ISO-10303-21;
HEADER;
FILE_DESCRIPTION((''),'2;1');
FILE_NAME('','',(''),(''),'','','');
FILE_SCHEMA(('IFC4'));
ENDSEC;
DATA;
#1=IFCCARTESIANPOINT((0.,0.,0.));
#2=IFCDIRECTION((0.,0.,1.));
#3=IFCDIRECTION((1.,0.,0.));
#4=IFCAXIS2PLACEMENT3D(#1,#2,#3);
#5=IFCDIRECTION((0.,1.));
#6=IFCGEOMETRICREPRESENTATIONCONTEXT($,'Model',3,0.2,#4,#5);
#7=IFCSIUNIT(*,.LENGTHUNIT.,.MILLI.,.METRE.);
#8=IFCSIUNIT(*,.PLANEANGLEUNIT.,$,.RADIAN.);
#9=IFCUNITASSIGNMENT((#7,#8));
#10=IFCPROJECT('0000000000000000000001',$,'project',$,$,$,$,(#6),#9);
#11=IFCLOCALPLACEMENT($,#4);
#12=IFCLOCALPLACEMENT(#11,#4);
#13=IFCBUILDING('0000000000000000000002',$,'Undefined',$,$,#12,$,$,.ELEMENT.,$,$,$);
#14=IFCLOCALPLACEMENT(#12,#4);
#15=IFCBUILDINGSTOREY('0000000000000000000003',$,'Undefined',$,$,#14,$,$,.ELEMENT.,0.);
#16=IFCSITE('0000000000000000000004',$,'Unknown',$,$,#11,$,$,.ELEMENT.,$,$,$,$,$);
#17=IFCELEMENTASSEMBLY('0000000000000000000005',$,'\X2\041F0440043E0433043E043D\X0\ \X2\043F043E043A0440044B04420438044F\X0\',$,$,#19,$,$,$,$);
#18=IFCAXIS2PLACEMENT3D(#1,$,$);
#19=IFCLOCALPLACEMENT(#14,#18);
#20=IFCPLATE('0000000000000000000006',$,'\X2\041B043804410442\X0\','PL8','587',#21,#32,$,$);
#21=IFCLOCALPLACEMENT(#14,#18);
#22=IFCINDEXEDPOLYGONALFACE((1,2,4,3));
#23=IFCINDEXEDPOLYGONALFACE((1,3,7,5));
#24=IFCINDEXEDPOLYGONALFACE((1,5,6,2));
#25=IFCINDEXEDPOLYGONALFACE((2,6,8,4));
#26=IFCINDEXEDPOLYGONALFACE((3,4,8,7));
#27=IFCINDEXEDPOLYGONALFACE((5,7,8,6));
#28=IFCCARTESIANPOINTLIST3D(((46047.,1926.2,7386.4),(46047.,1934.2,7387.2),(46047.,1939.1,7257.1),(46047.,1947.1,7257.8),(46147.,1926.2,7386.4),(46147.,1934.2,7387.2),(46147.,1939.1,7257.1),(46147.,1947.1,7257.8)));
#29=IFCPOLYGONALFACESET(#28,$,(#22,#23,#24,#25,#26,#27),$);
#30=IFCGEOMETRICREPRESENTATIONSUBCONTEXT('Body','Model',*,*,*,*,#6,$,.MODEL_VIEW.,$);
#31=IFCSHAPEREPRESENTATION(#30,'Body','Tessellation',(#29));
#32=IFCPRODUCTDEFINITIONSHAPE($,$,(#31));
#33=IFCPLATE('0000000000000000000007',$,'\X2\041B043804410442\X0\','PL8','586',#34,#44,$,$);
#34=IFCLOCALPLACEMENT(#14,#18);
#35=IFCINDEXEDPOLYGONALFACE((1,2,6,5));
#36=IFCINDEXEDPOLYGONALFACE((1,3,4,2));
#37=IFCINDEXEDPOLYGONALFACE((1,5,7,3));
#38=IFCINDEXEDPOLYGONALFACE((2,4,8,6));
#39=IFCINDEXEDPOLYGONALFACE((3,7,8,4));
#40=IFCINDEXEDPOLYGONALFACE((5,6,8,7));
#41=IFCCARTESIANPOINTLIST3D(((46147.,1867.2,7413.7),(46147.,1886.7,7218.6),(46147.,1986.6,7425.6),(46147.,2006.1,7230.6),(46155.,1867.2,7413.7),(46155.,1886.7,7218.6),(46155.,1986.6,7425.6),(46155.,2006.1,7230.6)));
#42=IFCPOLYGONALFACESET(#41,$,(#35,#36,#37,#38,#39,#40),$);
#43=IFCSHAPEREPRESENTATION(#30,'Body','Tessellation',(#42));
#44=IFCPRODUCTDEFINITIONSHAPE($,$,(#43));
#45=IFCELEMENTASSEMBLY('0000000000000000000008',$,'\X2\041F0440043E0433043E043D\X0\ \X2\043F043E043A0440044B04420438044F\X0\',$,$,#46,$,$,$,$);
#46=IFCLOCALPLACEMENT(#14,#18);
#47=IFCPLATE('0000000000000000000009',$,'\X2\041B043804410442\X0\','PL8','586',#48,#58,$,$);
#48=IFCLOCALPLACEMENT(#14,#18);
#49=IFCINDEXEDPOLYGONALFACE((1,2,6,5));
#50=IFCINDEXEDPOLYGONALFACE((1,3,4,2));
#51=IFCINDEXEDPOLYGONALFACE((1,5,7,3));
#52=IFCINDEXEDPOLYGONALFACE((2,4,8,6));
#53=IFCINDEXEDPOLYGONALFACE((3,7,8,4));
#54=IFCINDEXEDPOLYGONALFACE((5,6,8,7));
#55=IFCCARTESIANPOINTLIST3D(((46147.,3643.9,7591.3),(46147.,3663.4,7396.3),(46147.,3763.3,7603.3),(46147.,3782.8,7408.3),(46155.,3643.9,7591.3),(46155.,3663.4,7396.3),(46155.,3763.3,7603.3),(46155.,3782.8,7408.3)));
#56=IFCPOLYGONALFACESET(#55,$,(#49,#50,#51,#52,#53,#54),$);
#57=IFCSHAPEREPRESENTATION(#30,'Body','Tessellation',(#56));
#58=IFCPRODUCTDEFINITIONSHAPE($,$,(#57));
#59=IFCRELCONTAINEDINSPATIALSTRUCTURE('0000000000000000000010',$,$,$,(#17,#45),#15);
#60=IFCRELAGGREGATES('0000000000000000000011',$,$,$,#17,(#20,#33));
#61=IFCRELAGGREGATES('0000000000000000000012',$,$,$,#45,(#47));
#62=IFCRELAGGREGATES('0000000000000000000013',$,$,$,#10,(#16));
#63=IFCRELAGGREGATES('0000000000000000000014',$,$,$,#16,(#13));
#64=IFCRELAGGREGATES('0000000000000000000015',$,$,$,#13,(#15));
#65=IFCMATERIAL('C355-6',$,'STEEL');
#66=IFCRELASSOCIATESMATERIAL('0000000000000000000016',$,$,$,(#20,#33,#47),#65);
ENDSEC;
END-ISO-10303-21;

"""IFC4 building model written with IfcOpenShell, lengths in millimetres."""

from ifc_helpers import new_model, si_unit, direction, frame, origin_with_axes, place, context, subcontext, project, spatial, line, indexed_curve, outline, extrude, material, element, aggregate, save


model = new_model("IFC4")

# Units and contexts
model_context = context("Model", 3, precision=0.2, world=origin_with_axes(), true_north=direction((0.0, 1.0)))
body_context = subcontext(model_context, "Body", "Model", "MODEL_VIEW")
ifc_project = project(units=[si_unit("LENGTHUNIT", "METRE", prefix="MILLI"), si_unit("PLANEANGLEUNIT", "RADIAN")], contexts=[model_context])

# Site, building, storey
site_placement = place(None, origin_with_axes())
site = spatial("IfcSite", under=ifc_project, at=site_placement, Name="Unknown", CompositionType="ELEMENT")
building_placement = place(site_placement, origin_with_axes())
building = spatial("IfcBuilding", under=site, at=building_placement, Name="Undefined", CompositionType="ELEMENT")
storey_placement = place(building_placement, origin_with_axes())
storey = spatial("IfcBuildingStorey", under=building, at=storey_placement, Name="Undefined", CompositionType="ELEMENT", Elevation=0.0)

# Shared definitions
ifc_material_1 = material(Name="C355-6", Category="STEEL")

# Element assembly, plates
assembly_1_placement = place(storey_placement, frame((46000.0, 1936.7, 7322.1), z_axis=(0.0, 0.995037, 0.099504), x_axis=(1.0, 0.0, 0.0)))
assembly_1 = element("IfcElementAssembly", 1, at=assembly_1_placement, inside=storey, Name="Прогон покрытия")
plate_1_placement = place(assembly_1_placement, frame((47.0, -65.0, 0.0), z_axis=(0.0, 0.0, 1.0), x_axis=(1.0, 0.0, 0.0)))
plate_1 = element("IfcPlate", 2, at=plate_1_placement, material=ifc_material_1, Name="Лист", Description="PL8", ObjectType="587", context=body_context, shape_type="SolidModel", body=[
    extrude(outline(indexed_curve([(0.0, 0.0), (100.0, 0.0), (100.0, 130.0), (0.0, 130.0)], segments=[line(1, 2, 3, 4, 1)])), frame((0.0, 0.0, 4.0), z_axis=(0.0, 0.0, 1.0), x_axis=(1.0, 0.0, 0.0)), (0.0, 0.0, -1.0), 8.0),
])
plate_2_placement = place(assembly_1_placement, frame((151.0, -98.0, -60.0), z_axis=(-1.0, 0.0, 0.0), x_axis=(0.0, 0.0, 1.0)))
plate_2 = element("IfcPlate", 3, at=plate_2_placement, material=ifc_material_1, Name="Лист", Description="PL8", ObjectType="586", context=body_context, shape_type="SolidModel", body=[
    extrude(outline(indexed_curve([(0.0, 0.0), (120.0, 0.0), (120.0, 196.0), (0.0, 196.0)], segments=[line(1, 2, 3, 4, 1)])), frame((0.0, 0.0, 4.0), z_axis=(0.0, 0.0, 1.0), x_axis=(1.0, 0.0, 0.0)), (0.0, 0.0, -1.0), 8.0),
])
aggregate(assembly_1, [plate_1, plate_2])

# Element assembly, plate
assembly_2_placement = place(storey_placement, frame((46000.0, 3713.3, 7499.8), z_axis=(0.0, 0.995037, 0.099504), x_axis=(1.0, 0.0, 0.0)))
assembly_2 = element("IfcElementAssembly", 4, at=assembly_2_placement, inside=storey, Name="Прогон покрытия")
plate_3_placement = place(assembly_2_placement, frame((151.0, -98.0, -60.0), z_axis=(-1.0, 0.0, 0.0), x_axis=(0.0, 0.0, 1.0)))
plate_3 = element("IfcPlate", 5, at=plate_3_placement, material=ifc_material_1, Name="Лист", Description="PL8", ObjectType="586", context=body_context, shape_type="SolidModel", body=[
    extrude(outline(indexed_curve([(0.0, 0.0), (120.0, 0.0), (120.0, 196.0), (0.0, 196.0)], segments=[line(1, 2, 3, 4, 1)])), frame((0.0, 0.0, 4.0), z_axis=(0.0, 0.0, 1.0), x_axis=(1.0, 0.0, 0.0)), (0.0, 0.0, -1.0), 8.0),
])
aggregate(assembly_2, [plate_3])

save(model, "model.ifc")
